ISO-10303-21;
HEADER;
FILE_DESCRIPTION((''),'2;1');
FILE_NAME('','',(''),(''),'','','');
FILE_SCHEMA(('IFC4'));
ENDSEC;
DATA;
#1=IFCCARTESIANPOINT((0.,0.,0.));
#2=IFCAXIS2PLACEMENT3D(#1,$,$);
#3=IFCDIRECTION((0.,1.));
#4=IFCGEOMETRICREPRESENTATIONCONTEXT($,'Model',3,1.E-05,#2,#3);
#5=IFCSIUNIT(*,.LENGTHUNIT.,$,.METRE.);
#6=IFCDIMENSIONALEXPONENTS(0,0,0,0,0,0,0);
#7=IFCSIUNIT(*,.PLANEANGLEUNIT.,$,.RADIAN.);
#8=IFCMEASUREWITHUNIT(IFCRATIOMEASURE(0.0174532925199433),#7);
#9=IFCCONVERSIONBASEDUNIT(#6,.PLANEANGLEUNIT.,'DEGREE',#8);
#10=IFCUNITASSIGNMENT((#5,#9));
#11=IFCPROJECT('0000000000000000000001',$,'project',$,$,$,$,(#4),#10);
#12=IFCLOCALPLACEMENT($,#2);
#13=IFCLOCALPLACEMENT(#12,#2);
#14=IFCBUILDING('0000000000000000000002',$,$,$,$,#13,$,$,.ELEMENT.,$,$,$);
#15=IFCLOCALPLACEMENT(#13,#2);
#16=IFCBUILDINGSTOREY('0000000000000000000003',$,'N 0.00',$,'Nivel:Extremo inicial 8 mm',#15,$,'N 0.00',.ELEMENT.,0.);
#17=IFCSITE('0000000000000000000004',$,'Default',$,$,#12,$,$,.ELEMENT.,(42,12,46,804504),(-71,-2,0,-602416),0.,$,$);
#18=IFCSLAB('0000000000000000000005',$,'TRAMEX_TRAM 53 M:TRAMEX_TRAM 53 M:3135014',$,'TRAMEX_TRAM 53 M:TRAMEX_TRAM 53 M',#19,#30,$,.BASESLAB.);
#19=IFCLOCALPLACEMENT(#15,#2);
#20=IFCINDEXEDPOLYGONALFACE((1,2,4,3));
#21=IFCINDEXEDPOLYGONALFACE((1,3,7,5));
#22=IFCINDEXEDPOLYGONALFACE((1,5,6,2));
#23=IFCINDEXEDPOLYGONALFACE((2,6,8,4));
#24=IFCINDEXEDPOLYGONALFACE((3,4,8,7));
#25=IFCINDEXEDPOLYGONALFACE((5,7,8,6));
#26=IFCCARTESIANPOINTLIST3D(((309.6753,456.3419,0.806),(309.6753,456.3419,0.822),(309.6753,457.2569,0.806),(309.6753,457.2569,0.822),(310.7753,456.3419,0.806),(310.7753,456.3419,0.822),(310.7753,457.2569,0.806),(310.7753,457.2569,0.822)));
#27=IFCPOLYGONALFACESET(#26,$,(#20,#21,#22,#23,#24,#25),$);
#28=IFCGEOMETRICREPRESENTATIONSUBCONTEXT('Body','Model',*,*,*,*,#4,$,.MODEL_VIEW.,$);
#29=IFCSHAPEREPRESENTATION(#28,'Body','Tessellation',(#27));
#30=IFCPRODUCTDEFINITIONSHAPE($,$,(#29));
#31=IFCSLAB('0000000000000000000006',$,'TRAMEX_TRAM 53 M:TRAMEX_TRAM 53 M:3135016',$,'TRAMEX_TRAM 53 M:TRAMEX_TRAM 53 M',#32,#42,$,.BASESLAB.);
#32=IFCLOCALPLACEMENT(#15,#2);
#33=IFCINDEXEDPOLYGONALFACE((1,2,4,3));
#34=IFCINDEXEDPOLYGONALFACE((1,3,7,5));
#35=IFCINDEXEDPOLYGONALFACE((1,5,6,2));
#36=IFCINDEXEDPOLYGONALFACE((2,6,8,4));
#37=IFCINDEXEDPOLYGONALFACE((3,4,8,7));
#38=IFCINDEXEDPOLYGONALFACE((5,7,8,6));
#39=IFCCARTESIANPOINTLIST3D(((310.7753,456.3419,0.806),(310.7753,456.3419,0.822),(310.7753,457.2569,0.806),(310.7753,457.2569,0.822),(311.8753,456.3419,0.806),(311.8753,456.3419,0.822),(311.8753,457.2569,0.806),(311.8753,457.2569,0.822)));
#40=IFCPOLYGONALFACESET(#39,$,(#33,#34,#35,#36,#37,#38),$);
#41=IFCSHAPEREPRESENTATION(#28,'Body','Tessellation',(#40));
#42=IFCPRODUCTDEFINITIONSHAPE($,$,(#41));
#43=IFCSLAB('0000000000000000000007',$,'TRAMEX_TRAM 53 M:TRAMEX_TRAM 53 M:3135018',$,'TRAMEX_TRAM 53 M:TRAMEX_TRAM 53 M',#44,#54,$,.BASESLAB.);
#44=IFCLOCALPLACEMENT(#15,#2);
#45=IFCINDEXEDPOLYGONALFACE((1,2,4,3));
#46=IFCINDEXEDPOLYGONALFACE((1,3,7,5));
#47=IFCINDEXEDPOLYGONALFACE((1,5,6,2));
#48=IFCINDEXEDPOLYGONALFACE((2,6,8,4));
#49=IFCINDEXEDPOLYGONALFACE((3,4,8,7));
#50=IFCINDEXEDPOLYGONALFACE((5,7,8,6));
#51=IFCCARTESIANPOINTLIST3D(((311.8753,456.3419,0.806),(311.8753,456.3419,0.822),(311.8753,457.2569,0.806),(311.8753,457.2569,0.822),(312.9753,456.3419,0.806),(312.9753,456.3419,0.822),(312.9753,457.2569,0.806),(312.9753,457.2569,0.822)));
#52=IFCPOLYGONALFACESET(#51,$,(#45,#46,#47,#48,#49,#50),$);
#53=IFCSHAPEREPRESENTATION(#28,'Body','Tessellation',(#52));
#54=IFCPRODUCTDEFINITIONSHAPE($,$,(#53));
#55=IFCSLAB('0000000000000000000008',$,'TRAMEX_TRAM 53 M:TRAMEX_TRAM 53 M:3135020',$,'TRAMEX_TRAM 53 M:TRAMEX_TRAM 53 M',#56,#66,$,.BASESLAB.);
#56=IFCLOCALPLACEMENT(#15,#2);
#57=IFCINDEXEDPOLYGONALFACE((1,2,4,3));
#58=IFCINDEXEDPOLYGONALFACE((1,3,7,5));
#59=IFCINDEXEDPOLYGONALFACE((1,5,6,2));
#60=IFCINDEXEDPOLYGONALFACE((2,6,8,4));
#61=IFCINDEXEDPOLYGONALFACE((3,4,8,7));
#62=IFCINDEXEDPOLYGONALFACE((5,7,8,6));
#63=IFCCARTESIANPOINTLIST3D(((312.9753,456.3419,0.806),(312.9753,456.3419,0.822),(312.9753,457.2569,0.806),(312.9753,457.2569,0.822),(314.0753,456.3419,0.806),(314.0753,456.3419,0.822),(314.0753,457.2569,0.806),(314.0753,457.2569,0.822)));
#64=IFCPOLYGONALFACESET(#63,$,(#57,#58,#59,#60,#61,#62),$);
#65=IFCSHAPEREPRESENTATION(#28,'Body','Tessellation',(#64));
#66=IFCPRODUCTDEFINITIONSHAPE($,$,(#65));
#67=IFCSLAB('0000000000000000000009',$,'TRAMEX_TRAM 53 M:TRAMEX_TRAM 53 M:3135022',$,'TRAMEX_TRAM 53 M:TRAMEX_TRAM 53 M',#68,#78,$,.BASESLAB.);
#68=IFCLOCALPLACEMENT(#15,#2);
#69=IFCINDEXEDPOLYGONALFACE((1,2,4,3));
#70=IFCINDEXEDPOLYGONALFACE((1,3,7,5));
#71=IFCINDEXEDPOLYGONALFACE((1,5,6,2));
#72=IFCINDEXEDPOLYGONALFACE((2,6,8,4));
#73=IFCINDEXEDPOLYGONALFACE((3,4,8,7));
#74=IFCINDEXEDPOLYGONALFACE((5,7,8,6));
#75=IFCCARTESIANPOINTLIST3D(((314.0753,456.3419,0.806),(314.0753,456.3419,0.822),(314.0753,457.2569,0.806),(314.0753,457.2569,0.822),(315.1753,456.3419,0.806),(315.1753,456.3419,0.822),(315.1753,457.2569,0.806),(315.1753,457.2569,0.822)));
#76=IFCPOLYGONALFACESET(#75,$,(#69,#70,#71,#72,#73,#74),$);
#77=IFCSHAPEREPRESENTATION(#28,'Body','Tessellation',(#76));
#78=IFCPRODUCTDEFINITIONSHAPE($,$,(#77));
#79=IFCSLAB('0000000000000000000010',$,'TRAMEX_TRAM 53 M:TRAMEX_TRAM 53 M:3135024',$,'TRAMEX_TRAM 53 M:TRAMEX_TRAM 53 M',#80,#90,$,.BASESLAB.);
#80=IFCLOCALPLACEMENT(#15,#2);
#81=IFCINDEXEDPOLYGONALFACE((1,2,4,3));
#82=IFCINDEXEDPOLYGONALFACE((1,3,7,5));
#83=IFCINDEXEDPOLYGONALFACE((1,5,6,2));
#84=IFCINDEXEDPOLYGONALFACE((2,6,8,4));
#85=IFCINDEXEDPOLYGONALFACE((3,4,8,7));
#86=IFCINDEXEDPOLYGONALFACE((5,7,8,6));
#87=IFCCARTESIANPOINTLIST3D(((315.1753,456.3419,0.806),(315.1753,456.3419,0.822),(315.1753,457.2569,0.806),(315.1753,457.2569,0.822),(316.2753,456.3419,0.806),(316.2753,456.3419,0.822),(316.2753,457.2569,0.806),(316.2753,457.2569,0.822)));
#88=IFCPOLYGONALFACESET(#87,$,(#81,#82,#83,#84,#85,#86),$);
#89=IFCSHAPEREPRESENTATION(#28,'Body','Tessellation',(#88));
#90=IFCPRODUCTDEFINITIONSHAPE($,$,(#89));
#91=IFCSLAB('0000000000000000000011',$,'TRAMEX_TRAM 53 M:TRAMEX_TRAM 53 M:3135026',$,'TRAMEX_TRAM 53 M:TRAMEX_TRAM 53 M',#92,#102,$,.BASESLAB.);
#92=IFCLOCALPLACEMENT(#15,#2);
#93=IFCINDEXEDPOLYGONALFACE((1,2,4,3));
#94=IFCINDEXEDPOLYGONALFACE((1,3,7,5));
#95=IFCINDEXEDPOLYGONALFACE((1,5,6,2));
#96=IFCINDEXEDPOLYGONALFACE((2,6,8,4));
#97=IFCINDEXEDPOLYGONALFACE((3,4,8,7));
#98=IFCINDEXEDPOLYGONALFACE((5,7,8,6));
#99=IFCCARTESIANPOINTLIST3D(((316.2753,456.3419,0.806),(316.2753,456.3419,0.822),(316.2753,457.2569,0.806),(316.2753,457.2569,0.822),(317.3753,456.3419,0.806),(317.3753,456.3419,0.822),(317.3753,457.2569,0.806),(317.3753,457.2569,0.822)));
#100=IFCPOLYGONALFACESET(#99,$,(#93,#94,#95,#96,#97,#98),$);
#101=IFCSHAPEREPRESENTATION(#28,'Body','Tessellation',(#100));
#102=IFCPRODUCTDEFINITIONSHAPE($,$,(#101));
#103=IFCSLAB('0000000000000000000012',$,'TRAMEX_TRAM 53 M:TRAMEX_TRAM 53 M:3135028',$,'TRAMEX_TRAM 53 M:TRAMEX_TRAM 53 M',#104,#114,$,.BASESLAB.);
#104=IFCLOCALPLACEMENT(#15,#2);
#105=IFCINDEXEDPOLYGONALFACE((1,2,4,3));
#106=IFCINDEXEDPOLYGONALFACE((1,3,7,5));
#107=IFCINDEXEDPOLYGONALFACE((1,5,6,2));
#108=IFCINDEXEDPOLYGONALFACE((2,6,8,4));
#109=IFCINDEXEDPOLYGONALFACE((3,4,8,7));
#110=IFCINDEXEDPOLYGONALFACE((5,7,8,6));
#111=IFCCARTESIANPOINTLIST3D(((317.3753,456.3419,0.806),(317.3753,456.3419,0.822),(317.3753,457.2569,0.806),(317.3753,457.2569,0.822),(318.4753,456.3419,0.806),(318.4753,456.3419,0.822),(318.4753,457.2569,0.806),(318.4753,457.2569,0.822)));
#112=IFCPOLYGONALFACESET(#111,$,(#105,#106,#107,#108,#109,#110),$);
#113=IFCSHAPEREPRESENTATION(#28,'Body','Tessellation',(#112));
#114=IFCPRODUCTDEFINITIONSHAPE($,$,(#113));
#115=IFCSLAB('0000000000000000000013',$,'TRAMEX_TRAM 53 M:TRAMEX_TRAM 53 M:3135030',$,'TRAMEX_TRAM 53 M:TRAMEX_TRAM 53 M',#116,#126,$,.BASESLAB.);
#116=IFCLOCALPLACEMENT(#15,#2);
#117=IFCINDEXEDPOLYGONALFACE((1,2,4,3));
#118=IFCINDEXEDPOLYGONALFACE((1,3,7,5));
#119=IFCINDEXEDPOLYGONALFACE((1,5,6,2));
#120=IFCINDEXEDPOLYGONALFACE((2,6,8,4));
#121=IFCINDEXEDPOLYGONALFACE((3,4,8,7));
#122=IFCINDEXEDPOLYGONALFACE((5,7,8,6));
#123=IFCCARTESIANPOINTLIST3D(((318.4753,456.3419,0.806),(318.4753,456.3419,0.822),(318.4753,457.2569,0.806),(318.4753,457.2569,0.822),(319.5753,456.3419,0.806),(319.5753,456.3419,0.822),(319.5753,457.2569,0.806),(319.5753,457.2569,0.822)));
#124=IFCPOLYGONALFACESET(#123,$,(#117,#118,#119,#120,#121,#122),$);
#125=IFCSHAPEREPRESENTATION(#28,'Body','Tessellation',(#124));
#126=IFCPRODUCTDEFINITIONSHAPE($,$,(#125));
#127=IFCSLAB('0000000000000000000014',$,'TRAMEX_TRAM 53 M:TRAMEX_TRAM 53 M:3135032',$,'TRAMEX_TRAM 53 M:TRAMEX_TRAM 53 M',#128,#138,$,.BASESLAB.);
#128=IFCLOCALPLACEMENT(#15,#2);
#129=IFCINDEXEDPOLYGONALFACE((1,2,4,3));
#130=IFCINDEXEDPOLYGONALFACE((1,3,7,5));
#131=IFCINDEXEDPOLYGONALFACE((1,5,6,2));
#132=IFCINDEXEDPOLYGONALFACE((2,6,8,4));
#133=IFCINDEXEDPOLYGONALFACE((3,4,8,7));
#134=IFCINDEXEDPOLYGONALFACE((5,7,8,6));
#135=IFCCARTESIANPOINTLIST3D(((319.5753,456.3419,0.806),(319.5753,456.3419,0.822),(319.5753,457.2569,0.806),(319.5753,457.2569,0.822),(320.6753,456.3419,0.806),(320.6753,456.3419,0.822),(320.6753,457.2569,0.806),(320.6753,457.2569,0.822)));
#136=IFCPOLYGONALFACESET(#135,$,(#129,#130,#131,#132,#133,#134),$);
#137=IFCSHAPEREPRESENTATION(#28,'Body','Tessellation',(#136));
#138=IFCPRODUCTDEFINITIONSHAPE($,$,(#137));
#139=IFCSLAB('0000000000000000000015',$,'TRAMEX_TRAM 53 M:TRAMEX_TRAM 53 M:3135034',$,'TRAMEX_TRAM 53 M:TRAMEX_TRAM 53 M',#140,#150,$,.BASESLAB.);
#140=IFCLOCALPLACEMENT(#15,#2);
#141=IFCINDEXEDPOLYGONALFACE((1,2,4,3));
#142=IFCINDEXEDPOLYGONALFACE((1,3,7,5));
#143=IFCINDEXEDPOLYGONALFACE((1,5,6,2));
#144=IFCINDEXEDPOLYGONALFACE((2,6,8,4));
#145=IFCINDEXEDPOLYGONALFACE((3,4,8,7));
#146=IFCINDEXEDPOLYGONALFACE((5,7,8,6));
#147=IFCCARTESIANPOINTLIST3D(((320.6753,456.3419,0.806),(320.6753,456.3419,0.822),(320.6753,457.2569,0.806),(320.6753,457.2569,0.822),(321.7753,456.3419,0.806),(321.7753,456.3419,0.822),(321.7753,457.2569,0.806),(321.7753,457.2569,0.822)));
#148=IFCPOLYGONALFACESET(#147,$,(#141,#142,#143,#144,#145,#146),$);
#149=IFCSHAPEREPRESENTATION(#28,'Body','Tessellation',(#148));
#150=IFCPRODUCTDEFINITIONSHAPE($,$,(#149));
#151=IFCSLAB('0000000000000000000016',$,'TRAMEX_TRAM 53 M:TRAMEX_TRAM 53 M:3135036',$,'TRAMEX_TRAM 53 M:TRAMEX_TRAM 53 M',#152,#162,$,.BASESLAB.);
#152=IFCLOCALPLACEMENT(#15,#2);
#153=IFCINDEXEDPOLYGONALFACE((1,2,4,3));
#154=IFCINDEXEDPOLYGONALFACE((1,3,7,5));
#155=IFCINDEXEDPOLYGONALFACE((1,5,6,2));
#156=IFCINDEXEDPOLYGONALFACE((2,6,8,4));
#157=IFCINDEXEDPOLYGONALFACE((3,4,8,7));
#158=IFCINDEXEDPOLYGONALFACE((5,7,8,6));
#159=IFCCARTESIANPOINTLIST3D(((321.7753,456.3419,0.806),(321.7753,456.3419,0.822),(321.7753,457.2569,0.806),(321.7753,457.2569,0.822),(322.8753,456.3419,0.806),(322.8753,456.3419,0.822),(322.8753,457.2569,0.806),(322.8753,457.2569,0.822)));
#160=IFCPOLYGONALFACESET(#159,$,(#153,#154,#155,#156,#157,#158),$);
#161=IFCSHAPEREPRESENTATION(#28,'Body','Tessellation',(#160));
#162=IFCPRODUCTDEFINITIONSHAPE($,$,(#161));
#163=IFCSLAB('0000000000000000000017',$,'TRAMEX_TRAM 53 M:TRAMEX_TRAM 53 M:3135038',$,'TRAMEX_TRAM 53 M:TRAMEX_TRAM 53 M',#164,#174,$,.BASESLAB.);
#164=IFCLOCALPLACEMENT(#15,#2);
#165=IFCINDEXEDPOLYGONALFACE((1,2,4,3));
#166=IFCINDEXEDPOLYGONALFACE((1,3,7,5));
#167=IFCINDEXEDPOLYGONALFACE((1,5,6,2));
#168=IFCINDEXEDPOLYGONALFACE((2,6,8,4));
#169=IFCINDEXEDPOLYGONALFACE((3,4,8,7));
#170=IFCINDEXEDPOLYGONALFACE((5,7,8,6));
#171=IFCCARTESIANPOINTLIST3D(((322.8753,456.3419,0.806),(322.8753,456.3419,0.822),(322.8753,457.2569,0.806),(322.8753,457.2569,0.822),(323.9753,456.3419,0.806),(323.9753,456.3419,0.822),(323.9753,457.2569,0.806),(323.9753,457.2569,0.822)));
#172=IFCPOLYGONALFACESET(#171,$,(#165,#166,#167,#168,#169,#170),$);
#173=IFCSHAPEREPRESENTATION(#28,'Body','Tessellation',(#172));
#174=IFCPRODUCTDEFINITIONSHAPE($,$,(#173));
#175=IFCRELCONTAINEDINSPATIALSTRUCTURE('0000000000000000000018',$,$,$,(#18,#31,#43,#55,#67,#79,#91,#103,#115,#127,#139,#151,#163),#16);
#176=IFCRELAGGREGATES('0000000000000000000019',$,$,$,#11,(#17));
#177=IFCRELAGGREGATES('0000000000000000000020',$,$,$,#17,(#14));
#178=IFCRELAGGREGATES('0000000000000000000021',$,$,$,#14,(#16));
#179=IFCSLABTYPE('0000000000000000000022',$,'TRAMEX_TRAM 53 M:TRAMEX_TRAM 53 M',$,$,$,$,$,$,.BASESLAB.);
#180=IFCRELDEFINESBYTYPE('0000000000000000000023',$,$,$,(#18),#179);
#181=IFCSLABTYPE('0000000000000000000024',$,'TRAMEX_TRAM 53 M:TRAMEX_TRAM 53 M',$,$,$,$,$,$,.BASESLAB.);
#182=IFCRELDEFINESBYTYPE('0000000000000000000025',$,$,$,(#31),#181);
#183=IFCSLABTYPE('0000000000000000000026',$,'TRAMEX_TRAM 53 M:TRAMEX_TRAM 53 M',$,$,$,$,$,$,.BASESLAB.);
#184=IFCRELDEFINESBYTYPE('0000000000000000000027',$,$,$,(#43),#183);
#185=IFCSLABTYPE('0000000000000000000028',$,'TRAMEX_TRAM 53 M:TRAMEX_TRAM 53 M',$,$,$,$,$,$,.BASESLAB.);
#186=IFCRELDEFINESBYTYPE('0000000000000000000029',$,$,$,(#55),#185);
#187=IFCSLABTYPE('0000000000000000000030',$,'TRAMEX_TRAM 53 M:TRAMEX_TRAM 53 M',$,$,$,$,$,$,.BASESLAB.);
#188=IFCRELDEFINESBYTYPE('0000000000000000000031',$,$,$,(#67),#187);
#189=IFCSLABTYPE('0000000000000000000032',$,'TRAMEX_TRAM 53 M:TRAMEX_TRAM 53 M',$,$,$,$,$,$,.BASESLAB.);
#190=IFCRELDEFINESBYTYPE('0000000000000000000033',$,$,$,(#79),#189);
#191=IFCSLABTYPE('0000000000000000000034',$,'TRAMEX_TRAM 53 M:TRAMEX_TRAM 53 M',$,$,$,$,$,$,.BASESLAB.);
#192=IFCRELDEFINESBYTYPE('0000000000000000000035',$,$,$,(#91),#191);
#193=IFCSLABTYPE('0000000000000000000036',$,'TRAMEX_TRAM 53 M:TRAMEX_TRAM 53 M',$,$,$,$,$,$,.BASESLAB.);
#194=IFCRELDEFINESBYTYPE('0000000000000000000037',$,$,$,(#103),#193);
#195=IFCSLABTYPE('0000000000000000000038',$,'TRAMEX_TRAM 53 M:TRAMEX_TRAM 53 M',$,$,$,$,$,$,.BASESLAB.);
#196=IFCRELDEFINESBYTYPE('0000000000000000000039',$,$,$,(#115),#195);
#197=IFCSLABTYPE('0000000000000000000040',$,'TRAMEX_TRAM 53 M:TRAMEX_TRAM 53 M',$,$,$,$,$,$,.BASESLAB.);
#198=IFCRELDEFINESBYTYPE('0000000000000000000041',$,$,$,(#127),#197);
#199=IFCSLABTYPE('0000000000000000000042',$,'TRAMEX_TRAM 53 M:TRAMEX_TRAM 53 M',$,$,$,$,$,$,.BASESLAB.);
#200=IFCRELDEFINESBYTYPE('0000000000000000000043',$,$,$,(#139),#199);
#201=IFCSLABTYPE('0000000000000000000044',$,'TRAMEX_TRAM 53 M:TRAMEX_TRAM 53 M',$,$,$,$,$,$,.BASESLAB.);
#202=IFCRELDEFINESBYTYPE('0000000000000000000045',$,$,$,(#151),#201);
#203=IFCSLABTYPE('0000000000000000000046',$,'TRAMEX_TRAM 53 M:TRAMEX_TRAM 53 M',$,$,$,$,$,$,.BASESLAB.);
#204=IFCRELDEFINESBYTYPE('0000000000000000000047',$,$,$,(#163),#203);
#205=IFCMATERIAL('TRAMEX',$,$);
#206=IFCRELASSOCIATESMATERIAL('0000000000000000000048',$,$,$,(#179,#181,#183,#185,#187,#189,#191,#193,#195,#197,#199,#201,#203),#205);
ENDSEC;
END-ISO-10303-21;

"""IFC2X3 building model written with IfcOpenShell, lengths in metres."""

from ifc_helpers import new_model, entity, si_unit, converted_unit, direction, frame, frame_2d, origin, place, context, subcontext, project, spatial, rectangle, extrude, material, type_object, element, save


model = new_model("IFC2X3")

# Units and contexts
model_context = context("Model", 3, precision=1e-05, world=origin(), true_north=direction((0.0, 1.0)))
body_context = subcontext(model_context, "Body", "Model", "MODEL_VIEW")
ifc_project = project(units=[si_unit("LENGTHUNIT", "METRE"), converted_unit("PLANEANGLEUNIT", "DEGREE", entity("IfcRatioMeasure", 0.0174532925199433), si_unit("PLANEANGLEUNIT", "RADIAN"), dimensions=[0, 0, 0, 0, 0, 0, 0])], contexts=[model_context])

# Site, building, storey
site_placement = place(None, origin())
site = spatial("IfcSite", under=ifc_project, at=site_placement, Name="Default", CompositionType="ELEMENT", RefLatitude=(42, 12, 46, 804504), RefLongitude=(-71, -2, 0, -602416), RefElevation=0.0)
building_placement = place(site_placement, origin())
building = spatial("IfcBuilding", under=site, at=building_placement, CompositionType="ELEMENT")
storey_placement = place(building_placement, origin())
storey = spatial("IfcBuildingStorey", under=building, at=storey_placement, Name="N 0.00", ObjectType="Nivel:Extremo inicial 8 mm", LongName="N 0.00", CompositionType="ELEMENT", Elevation=0.0)

# Slabs
ifc_material_1 = material(Name="TRAMEX")
slab_type_1 = type_object("IfcSlabType", Name="TRAMEX_TRAM 53 M:TRAMEX_TRAM 53 M", PredefinedType="BASESLAB", material=ifc_material_1)
slab_1_placement = place(storey_placement, origin())
element("IfcSlab", 1, at=slab_1_placement, inside=storey, type_object=slab_type_1, Name="TRAMEX_TRAM 53 M:TRAMEX_TRAM 53 M:3135014", ObjectType="TRAMEX_TRAM 53 M:TRAMEX_TRAM 53 M", PredefinedType="BASESLAB", context=body_context, shape_type="SweptSolid", body=[
    extrude(rectangle(XDim=1.1, YDim=0.915, at=frame_2d((0.0, 0.0), x_axis=(1.0, 0.0))), frame((310.2253, 456.7994, 0.806), z_axis=(0.0, 0.0, 1.0), x_axis=(-1.0, 0.0, 0.0)), (0.0, 0.0, 1.0), 0.016),
])
slab_type_2 = type_object("IfcSlabType", Name="TRAMEX_TRAM 53 M:TRAMEX_TRAM 53 M", PredefinedType="BASESLAB", material=ifc_material_1)
slab_2_placement = place(storey_placement, origin())
element("IfcSlab", 2, at=slab_2_placement, inside=storey, type_object=slab_type_2, Name="TRAMEX_TRAM 53 M:TRAMEX_TRAM 53 M:3135016", ObjectType="TRAMEX_TRAM 53 M:TRAMEX_TRAM 53 M", PredefinedType="BASESLAB", context=body_context, shape_type="SweptSolid", body=[
    extrude(rectangle(XDim=1.1, YDim=0.915, at=frame_2d((0.0, 0.0), x_axis=(1.0, 0.0))), frame((311.3253, 456.7994, 0.806), z_axis=(0.0, 0.0, 1.0), x_axis=(-1.0, 0.0, 0.0)), (0.0, 0.0, 1.0), 0.016),
])
slab_type_3 = type_object("IfcSlabType", Name="TRAMEX_TRAM 53 M:TRAMEX_TRAM 53 M", PredefinedType="BASESLAB", material=ifc_material_1)
slab_3_placement = place(storey_placement, origin())
element("IfcSlab", 3, at=slab_3_placement, inside=storey, type_object=slab_type_3, Name="TRAMEX_TRAM 53 M:TRAMEX_TRAM 53 M:3135018", ObjectType="TRAMEX_TRAM 53 M:TRAMEX_TRAM 53 M", PredefinedType="BASESLAB", context=body_context, shape_type="SweptSolid", body=[
    extrude(rectangle(XDim=1.1, YDim=0.915, at=frame_2d((0.0, 0.0), x_axis=(1.0, 0.0))), frame((312.4253, 456.7994, 0.806), z_axis=(0.0, 0.0, 1.0), x_axis=(-1.0, 0.0, 0.0)), (0.0, 0.0, 1.0), 0.016),
])
slab_type_4 = type_object("IfcSlabType", Name="TRAMEX_TRAM 53 M:TRAMEX_TRAM 53 M", PredefinedType="BASESLAB", material=ifc_material_1)
slab_4_placement = place(storey_placement, origin())
element("IfcSlab", 4, at=slab_4_placement, inside=storey, type_object=slab_type_4, Name="TRAMEX_TRAM 53 M:TRAMEX_TRAM 53 M:3135020", ObjectType="TRAMEX_TRAM 53 M:TRAMEX_TRAM 53 M", PredefinedType="BASESLAB", context=body_context, shape_type="SweptSolid", body=[
    extrude(rectangle(XDim=1.1, YDim=0.915, at=frame_2d((0.0, 0.0), x_axis=(1.0, 0.0))), frame((313.5253, 456.7994, 0.806), z_axis=(0.0, 0.0, 1.0), x_axis=(-1.0, 0.0, 0.0)), (0.0, 0.0, 1.0), 0.016),
])
slab_type_5 = type_object("IfcSlabType", Name="TRAMEX_TRAM 53 M:TRAMEX_TRAM 53 M", PredefinedType="BASESLAB", material=ifc_material_1)
slab_5_placement = place(storey_placement, origin())
element("IfcSlab", 5, at=slab_5_placement, inside=storey, type_object=slab_type_5, Name="TRAMEX_TRAM 53 M:TRAMEX_TRAM 53 M:3135022", ObjectType="TRAMEX_TRAM 53 M:TRAMEX_TRAM 53 M", PredefinedType="BASESLAB", context=body_context, shape_type="SweptSolid", body=[
    extrude(rectangle(XDim=1.1, YDim=0.915, at=frame_2d((0.0, 0.0), x_axis=(1.0, 0.0))), frame((314.6253, 456.7994, 0.806), z_axis=(0.0, 0.0, 1.0), x_axis=(-1.0, 0.0, 0.0)), (0.0, 0.0, 1.0), 0.016),
])
slab_type_6 = type_object("IfcSlabType", Name="TRAMEX_TRAM 53 M:TRAMEX_TRAM 53 M", PredefinedType="BASESLAB", material=ifc_material_1)
slab_6_placement = place(storey_placement, origin())
element("IfcSlab", 6, at=slab_6_placement, inside=storey, type_object=slab_type_6, Name="TRAMEX_TRAM 53 M:TRAMEX_TRAM 53 M:3135024", ObjectType="TRAMEX_TRAM 53 M:TRAMEX_TRAM 53 M", PredefinedType="BASESLAB", context=body_context, shape_type="SweptSolid", body=[
    extrude(rectangle(XDim=1.1, YDim=0.915, at=frame_2d((0.0, 0.0), x_axis=(1.0, 0.0))), frame((315.7253, 456.7994, 0.806), z_axis=(0.0, 0.0, 1.0), x_axis=(-1.0, 0.0, 0.0)), (0.0, 0.0, 1.0), 0.016),
])
slab_type_7 = type_object("IfcSlabType", Name="TRAMEX_TRAM 53 M:TRAMEX_TRAM 53 M", PredefinedType="BASESLAB", material=ifc_material_1)
slab_7_placement = place(storey_placement, origin())
element("IfcSlab", 7, at=slab_7_placement, inside=storey, type_object=slab_type_7, Name="TRAMEX_TRAM 53 M:TRAMEX_TRAM 53 M:3135026", ObjectType="TRAMEX_TRAM 53 M:TRAMEX_TRAM 53 M", PredefinedType="BASESLAB", context=body_context, shape_type="SweptSolid", body=[
    extrude(rectangle(XDim=1.1, YDim=0.915, at=frame_2d((0.0, 0.0), x_axis=(1.0, 0.0))), frame((316.8253, 456.7994, 0.806), z_axis=(0.0, 0.0, 1.0), x_axis=(-1.0, 0.0, 0.0)), (0.0, 0.0, 1.0), 0.016),
])
slab_type_8 = type_object("IfcSlabType", Name="TRAMEX_TRAM 53 M:TRAMEX_TRAM 53 M", PredefinedType="BASESLAB", material=ifc_material_1)
slab_8_placement = place(storey_placement, origin())
element("IfcSlab", 8, at=slab_8_placement, inside=storey, type_object=slab_type_8, Name="TRAMEX_TRAM 53 M:TRAMEX_TRAM 53 M:3135028", ObjectType="TRAMEX_TRAM 53 M:TRAMEX_TRAM 53 M", PredefinedType="BASESLAB", context=body_context, shape_type="SweptSolid", body=[
    extrude(rectangle(XDim=1.1, YDim=0.915, at=frame_2d((0.0, 0.0), x_axis=(1.0, 0.0))), frame((317.9253, 456.7994, 0.806), z_axis=(0.0, 0.0, 1.0), x_axis=(-1.0, 0.0, 0.0)), (0.0, 0.0, 1.0), 0.016),
])
slab_type_9 = type_object("IfcSlabType", Name="TRAMEX_TRAM 53 M:TRAMEX_TRAM 53 M", PredefinedType="BASESLAB", material=ifc_material_1)
slab_9_placement = place(storey_placement, origin())
element("IfcSlab", 9, at=slab_9_placement, inside=storey, type_object=slab_type_9, Name="TRAMEX_TRAM 53 M:TRAMEX_TRAM 53 M:3135030", ObjectType="TRAMEX_TRAM 53 M:TRAMEX_TRAM 53 M", PredefinedType="BASESLAB", context=body_context, shape_type="SweptSolid", body=[
    extrude(rectangle(XDim=1.1, YDim=0.915, at=frame_2d((0.0, 0.0), x_axis=(1.0, 0.0))), frame((319.0253, 456.7994, 0.806), z_axis=(0.0, 0.0, 1.0), x_axis=(-1.0, 0.0, 0.0)), (0.0, 0.0, 1.0), 0.016),
])
slab_type_10 = type_object("IfcSlabType", Name="TRAMEX_TRAM 53 M:TRAMEX_TRAM 53 M", PredefinedType="BASESLAB", material=ifc_material_1)
slab_10_placement = place(storey_placement, origin())
element("IfcSlab", 10, at=slab_10_placement, inside=storey, type_object=slab_type_10, Name="TRAMEX_TRAM 53 M:TRAMEX_TRAM 53 M:3135032", ObjectType="TRAMEX_TRAM 53 M:TRAMEX_TRAM 53 M", PredefinedType="BASESLAB", context=body_context, shape_type="SweptSolid", body=[
    extrude(rectangle(XDim=1.1, YDim=0.915, at=frame_2d((0.0, 0.0), x_axis=(1.0, 0.0))), frame((320.1253, 456.7994, 0.806), z_axis=(0.0, 0.0, 1.0), x_axis=(-1.0, 0.0, 0.0)), (0.0, 0.0, 1.0), 0.016),
])
slab_type_11 = type_object("IfcSlabType", Name="TRAMEX_TRAM 53 M:TRAMEX_TRAM 53 M", PredefinedType="BASESLAB", material=ifc_material_1)
slab_11_placement = place(storey_placement, origin())
element("IfcSlab", 11, at=slab_11_placement, inside=storey, type_object=slab_type_11, Name="TRAMEX_TRAM 53 M:TRAMEX_TRAM 53 M:3135034", ObjectType="TRAMEX_TRAM 53 M:TRAMEX_TRAM 53 M", PredefinedType="BASESLAB", context=body_context, shape_type="SweptSolid", body=[
    extrude(rectangle(XDim=1.1, YDim=0.915, at=frame_2d((0.0, 0.0), x_axis=(1.0, 0.0))), frame((321.2253, 456.7994, 0.806), z_axis=(0.0, 0.0, 1.0), x_axis=(-1.0, 0.0, 0.0)), (0.0, 0.0, 1.0), 0.016),
])
slab_type_12 = type_object("IfcSlabType", Name="TRAMEX_TRAM 53 M:TRAMEX_TRAM 53 M", PredefinedType="BASESLAB", material=ifc_material_1)
slab_12_placement = place(storey_placement, origin())
element("IfcSlab", 12, at=slab_12_placement, inside=storey, type_object=slab_type_12, Name="TRAMEX_TRAM 53 M:TRAMEX_TRAM 53 M:3135036", ObjectType="TRAMEX_TRAM 53 M:TRAMEX_TRAM 53 M", PredefinedType="BASESLAB", context=body_context, shape_type="SweptSolid", body=[
    extrude(rectangle(XDim=1.1, YDim=0.915, at=frame_2d((0.0, 0.0), x_axis=(1.0, 0.0))), frame((322.3253, 456.7994, 0.806), z_axis=(0.0, 0.0, 1.0), x_axis=(-1.0, 0.0, 0.0)), (0.0, 0.0, 1.0), 0.016),
])
slab_type_13 = type_object("IfcSlabType", Name="TRAMEX_TRAM 53 M:TRAMEX_TRAM 53 M", PredefinedType="BASESLAB", material=ifc_material_1)
slab_13_placement = place(storey_placement, origin())
element("IfcSlab", 13, at=slab_13_placement, inside=storey, type_object=slab_type_13, Name="TRAMEX_TRAM 53 M:TRAMEX_TRAM 53 M:3135038", ObjectType="TRAMEX_TRAM 53 M:TRAMEX_TRAM 53 M", PredefinedType="BASESLAB", context=body_context, shape_type="SweptSolid", body=[
    extrude(rectangle(XDim=1.1, YDim=0.915, at=frame_2d((0.0, 0.0), x_axis=(1.0, 0.0))), frame((323.4253, 456.7994, 0.806), z_axis=(0.0, 0.0, 1.0), x_axis=(-1.0, 0.0, 0.0)), (0.0, 0.0, 1.0), 0.016),
])

save(model, "model.ifc")
